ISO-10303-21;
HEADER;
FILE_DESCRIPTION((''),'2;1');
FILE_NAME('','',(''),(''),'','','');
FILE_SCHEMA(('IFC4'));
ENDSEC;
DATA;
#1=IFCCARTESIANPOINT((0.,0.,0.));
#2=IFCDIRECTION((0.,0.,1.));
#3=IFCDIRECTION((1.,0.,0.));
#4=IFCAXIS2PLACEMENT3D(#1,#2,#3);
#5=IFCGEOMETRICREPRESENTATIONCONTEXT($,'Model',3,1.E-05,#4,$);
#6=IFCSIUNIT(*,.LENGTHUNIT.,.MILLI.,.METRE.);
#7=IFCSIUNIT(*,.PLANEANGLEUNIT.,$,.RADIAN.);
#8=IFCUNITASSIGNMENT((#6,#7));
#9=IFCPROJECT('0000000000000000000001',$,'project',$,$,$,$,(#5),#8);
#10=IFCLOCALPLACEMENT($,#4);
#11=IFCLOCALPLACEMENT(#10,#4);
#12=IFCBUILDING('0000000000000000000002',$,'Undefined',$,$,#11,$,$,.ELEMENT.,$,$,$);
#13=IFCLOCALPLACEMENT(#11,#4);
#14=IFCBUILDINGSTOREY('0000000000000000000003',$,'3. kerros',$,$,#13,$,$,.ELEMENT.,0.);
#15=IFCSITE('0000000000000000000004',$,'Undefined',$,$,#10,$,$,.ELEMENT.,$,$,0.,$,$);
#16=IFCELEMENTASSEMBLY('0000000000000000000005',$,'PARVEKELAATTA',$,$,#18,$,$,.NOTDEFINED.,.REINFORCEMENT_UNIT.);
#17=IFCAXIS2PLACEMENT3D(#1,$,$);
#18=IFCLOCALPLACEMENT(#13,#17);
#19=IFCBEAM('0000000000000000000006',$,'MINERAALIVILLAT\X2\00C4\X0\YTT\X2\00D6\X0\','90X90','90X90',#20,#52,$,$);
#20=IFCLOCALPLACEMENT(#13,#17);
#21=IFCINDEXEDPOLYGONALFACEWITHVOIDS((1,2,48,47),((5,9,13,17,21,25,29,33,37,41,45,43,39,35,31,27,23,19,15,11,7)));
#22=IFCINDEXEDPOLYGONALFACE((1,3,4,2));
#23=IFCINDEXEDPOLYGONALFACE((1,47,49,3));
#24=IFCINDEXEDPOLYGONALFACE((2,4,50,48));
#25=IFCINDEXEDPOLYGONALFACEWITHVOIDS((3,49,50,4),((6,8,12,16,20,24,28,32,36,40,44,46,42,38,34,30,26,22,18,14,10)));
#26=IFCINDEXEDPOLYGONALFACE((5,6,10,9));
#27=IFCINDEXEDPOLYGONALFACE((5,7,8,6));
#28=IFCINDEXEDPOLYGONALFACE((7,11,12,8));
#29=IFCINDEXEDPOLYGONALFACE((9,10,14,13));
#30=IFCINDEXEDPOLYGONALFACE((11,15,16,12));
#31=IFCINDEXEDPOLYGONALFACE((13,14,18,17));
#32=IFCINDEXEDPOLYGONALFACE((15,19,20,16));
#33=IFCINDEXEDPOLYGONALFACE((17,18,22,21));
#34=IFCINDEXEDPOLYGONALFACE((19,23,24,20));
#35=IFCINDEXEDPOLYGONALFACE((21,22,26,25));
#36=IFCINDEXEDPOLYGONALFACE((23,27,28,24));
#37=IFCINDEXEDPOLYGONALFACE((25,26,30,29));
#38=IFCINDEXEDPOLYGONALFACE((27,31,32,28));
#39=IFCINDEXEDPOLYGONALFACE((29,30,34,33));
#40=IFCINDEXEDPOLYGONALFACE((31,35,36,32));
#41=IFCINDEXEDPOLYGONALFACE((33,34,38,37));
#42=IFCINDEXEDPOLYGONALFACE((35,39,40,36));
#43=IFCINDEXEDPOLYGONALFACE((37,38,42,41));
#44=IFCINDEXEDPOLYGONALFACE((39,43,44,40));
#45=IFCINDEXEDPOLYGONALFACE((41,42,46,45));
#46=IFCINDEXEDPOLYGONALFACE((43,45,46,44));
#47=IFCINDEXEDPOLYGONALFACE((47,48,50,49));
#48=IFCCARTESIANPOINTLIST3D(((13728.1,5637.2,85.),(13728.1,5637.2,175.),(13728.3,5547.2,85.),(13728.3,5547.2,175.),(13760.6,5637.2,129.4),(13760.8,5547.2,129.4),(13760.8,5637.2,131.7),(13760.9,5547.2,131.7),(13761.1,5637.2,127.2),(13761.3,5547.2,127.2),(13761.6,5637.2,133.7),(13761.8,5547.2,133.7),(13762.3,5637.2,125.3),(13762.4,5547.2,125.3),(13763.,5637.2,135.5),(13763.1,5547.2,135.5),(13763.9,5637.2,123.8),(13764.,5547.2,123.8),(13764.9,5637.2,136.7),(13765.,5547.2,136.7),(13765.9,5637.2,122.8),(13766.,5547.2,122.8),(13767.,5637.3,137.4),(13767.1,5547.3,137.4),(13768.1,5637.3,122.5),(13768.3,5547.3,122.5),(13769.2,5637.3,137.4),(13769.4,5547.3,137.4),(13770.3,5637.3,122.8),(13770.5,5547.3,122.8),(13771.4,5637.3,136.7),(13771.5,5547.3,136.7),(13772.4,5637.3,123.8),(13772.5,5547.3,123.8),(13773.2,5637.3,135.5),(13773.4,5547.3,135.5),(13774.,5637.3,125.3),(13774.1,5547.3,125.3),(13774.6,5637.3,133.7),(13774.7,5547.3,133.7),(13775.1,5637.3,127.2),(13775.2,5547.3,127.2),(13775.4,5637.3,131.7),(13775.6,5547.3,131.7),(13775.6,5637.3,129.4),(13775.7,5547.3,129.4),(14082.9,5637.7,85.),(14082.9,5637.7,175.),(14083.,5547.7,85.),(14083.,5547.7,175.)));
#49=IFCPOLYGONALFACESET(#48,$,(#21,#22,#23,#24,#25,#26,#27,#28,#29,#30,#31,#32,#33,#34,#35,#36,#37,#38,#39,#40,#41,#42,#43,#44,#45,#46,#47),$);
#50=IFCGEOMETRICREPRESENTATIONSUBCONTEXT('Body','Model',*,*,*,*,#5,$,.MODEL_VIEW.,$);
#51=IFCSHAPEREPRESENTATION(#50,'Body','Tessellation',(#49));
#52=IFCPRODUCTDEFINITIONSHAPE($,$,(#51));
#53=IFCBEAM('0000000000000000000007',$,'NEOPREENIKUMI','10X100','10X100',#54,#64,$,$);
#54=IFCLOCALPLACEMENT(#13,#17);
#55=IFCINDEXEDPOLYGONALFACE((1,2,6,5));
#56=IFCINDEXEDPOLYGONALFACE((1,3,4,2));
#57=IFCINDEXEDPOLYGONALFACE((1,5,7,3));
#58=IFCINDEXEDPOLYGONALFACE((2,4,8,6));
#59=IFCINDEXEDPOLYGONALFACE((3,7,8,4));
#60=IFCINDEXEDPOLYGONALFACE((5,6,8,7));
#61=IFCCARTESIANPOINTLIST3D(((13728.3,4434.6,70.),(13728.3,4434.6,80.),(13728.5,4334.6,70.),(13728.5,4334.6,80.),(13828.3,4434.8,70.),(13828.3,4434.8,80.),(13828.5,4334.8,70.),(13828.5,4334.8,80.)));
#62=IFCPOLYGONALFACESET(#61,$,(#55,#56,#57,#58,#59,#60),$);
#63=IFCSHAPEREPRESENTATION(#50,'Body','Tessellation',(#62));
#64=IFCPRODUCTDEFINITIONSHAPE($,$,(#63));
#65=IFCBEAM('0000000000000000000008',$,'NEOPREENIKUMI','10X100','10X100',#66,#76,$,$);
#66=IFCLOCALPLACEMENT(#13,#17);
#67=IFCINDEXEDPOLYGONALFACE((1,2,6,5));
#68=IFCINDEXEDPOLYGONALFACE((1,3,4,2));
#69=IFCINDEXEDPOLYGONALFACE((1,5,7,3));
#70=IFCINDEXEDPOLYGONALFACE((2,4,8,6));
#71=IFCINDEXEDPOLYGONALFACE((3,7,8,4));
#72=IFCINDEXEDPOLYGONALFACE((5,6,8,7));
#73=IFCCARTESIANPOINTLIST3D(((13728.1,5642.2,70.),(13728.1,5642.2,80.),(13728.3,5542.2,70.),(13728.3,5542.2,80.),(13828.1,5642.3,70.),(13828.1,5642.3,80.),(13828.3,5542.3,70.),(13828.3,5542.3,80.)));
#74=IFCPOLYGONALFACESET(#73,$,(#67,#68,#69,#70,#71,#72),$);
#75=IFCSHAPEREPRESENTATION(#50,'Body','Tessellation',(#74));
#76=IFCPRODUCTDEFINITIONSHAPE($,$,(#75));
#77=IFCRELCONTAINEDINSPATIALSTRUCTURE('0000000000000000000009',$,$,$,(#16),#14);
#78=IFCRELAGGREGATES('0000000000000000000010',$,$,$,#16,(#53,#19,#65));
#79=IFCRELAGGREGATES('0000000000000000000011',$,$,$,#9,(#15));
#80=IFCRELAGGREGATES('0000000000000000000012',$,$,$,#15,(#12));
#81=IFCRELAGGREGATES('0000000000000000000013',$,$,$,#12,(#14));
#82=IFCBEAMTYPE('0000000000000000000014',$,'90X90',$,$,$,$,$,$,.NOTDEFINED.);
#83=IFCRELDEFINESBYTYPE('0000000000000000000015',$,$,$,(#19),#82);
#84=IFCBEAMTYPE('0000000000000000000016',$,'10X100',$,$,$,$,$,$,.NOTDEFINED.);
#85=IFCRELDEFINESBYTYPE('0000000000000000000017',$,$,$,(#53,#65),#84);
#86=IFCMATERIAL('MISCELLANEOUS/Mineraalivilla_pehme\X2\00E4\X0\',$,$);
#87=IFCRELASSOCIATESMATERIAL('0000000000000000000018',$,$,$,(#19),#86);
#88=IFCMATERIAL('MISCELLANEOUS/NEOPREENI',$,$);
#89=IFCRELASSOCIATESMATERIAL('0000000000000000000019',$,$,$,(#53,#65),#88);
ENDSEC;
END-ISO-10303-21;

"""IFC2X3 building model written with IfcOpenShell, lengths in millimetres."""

from ifc_helpers import new_model, si_unit, frame, origin_with_axes, origin_2d_with_axis, place, context, subcontext, project, spatial, rectangle, circle, extrude, boolean, material, type_object, element, aggregate, save


model = new_model("IFC2X3")

# Units and contexts
model_context = context("Model", 3, precision=1e-05, world=origin_with_axes())
body_context = subcontext(model_context, "Body", "Model", "MODEL_VIEW")
ifc_project = project(units=[si_unit("LENGTHUNIT", "METRE", prefix="MILLI"), si_unit("PLANEANGLEUNIT", "RADIAN")], contexts=[model_context])

# Site, building, storey
site_placement = place(None, origin_with_axes())
site = spatial("IfcSite", under=ifc_project, at=site_placement, Name="Undefined", CompositionType="ELEMENT", RefElevation=0.0)
building_placement = place(site_placement, origin_with_axes())
building = spatial("IfcBuilding", under=site, at=building_placement, Name="Undefined", CompositionType="ELEMENT")
storey_placement = place(building_placement, origin_with_axes())
storey = spatial("IfcBuildingStorey", under=building, at=storey_placement, Name="3. kerros", CompositionType="ELEMENT", Elevation=0.0)

# Element assembly, beams
assembly_1_placement = place(storey_placement, origin_with_axes())
assembly_1 = element("IfcElementAssembly", 1, at=assembly_1_placement, inside=storey, Name="PARVEKELAATTA", AssemblyPlace="NOTDEFINED", PredefinedType="REINFORCEMENT_UNIT")
ifc_material_1 = material(Name="MISCELLANEOUS/Mineraalivilla_pehmeä")
beam_type_1 = type_object("IfcBeamType", Name="90X90", PredefinedType="NOTDEFINED")
beam_1_placement = place(assembly_1_placement, frame((13728.2, 5592.2, 130.0), z_axis=(-0.001348, 0.999999, 0.0), x_axis=(0.999999, 0.001348, 0.0)))
beam_1 = element("IfcBeam", 2, at=beam_1_placement, type_object=beam_type_1, material=ifc_material_1, Name="MINERAALIVILLATÄYTTÖ", Description="90X90", ObjectType="90X90", context=body_context, shape_type="CSG", body=[
    boolean("DIFFERENCE", extrude(rectangle(XDim=90.0, YDim=90.0, at=origin_2d_with_axis()), frame((354.8, 0.0, 0.0), z_axis=(-1.0, 0.0, 0.0), x_axis=(0.0, -1.0, 0.0)), (0.0, 0.0, 1.0), 354.8), extrude(circle(Radius=7.5, at=origin_2d_with_axis()), frame((40.0, 0.0, 80.0), z_axis=(0.000032, 0.0, -1.0), x_axis=(0.0, 1.0, 0.0)), (0.0, 0.0, 1.0), 140.0)),
])
ifc_material_2 = material(Name="MISCELLANEOUS/NEOPREENI")
beam_type_2 = type_object("IfcBeamType", Name="10X100", PredefinedType="NOTDEFINED")
beam_2_placement = place(assembly_1_placement, frame((13778.5, 4334.7, 75.0), z_axis=(0.0, 0.0, 1.0), x_axis=(-0.001867, 0.999998, 0.0)))
beam_2 = element("IfcBeam", 3, at=beam_2_placement, type_object=beam_type_2, material=ifc_material_2, Name="NEOPREENIKUMI", Description="10X100", ObjectType="10X100", context=body_context, shape_type="SweptSolid", body=[
    extrude(rectangle(XDim=100.0, YDim=10.0, at=origin_2d_with_axis()), frame((100.0, 0.0, 0.0), z_axis=(-1.0, 0.0, 0.0), x_axis=(0.0, -1.0, 0.0)), (0.0, 0.0, 1.0), 100.0),
])
beam_3_placement = place(assembly_1_placement, frame((13778.3, 5542.3, 75.0), z_axis=(0.0, 0.0, 1.0), x_axis=(-0.001867, 0.999998, 0.0)))
beam_3 = element("IfcBeam", 4, at=beam_3_placement, type_object=beam_type_2, material=ifc_material_2, Name="NEOPREENIKUMI", Description="10X100", ObjectType="10X100", context=body_context, shape_type="SweptSolid", body=[
    extrude(rectangle(XDim=100.0, YDim=10.0, at=origin_2d_with_axis()), frame((100.0, 0.0, 0.0), z_axis=(-1.0, 0.0, 0.0), x_axis=(0.0, -1.0, 0.0)), (0.0, 0.0, 1.0), 100.0),
])
aggregate(assembly_1, [beam_2, beam_1, beam_3])

save(model, "model.ifc")
